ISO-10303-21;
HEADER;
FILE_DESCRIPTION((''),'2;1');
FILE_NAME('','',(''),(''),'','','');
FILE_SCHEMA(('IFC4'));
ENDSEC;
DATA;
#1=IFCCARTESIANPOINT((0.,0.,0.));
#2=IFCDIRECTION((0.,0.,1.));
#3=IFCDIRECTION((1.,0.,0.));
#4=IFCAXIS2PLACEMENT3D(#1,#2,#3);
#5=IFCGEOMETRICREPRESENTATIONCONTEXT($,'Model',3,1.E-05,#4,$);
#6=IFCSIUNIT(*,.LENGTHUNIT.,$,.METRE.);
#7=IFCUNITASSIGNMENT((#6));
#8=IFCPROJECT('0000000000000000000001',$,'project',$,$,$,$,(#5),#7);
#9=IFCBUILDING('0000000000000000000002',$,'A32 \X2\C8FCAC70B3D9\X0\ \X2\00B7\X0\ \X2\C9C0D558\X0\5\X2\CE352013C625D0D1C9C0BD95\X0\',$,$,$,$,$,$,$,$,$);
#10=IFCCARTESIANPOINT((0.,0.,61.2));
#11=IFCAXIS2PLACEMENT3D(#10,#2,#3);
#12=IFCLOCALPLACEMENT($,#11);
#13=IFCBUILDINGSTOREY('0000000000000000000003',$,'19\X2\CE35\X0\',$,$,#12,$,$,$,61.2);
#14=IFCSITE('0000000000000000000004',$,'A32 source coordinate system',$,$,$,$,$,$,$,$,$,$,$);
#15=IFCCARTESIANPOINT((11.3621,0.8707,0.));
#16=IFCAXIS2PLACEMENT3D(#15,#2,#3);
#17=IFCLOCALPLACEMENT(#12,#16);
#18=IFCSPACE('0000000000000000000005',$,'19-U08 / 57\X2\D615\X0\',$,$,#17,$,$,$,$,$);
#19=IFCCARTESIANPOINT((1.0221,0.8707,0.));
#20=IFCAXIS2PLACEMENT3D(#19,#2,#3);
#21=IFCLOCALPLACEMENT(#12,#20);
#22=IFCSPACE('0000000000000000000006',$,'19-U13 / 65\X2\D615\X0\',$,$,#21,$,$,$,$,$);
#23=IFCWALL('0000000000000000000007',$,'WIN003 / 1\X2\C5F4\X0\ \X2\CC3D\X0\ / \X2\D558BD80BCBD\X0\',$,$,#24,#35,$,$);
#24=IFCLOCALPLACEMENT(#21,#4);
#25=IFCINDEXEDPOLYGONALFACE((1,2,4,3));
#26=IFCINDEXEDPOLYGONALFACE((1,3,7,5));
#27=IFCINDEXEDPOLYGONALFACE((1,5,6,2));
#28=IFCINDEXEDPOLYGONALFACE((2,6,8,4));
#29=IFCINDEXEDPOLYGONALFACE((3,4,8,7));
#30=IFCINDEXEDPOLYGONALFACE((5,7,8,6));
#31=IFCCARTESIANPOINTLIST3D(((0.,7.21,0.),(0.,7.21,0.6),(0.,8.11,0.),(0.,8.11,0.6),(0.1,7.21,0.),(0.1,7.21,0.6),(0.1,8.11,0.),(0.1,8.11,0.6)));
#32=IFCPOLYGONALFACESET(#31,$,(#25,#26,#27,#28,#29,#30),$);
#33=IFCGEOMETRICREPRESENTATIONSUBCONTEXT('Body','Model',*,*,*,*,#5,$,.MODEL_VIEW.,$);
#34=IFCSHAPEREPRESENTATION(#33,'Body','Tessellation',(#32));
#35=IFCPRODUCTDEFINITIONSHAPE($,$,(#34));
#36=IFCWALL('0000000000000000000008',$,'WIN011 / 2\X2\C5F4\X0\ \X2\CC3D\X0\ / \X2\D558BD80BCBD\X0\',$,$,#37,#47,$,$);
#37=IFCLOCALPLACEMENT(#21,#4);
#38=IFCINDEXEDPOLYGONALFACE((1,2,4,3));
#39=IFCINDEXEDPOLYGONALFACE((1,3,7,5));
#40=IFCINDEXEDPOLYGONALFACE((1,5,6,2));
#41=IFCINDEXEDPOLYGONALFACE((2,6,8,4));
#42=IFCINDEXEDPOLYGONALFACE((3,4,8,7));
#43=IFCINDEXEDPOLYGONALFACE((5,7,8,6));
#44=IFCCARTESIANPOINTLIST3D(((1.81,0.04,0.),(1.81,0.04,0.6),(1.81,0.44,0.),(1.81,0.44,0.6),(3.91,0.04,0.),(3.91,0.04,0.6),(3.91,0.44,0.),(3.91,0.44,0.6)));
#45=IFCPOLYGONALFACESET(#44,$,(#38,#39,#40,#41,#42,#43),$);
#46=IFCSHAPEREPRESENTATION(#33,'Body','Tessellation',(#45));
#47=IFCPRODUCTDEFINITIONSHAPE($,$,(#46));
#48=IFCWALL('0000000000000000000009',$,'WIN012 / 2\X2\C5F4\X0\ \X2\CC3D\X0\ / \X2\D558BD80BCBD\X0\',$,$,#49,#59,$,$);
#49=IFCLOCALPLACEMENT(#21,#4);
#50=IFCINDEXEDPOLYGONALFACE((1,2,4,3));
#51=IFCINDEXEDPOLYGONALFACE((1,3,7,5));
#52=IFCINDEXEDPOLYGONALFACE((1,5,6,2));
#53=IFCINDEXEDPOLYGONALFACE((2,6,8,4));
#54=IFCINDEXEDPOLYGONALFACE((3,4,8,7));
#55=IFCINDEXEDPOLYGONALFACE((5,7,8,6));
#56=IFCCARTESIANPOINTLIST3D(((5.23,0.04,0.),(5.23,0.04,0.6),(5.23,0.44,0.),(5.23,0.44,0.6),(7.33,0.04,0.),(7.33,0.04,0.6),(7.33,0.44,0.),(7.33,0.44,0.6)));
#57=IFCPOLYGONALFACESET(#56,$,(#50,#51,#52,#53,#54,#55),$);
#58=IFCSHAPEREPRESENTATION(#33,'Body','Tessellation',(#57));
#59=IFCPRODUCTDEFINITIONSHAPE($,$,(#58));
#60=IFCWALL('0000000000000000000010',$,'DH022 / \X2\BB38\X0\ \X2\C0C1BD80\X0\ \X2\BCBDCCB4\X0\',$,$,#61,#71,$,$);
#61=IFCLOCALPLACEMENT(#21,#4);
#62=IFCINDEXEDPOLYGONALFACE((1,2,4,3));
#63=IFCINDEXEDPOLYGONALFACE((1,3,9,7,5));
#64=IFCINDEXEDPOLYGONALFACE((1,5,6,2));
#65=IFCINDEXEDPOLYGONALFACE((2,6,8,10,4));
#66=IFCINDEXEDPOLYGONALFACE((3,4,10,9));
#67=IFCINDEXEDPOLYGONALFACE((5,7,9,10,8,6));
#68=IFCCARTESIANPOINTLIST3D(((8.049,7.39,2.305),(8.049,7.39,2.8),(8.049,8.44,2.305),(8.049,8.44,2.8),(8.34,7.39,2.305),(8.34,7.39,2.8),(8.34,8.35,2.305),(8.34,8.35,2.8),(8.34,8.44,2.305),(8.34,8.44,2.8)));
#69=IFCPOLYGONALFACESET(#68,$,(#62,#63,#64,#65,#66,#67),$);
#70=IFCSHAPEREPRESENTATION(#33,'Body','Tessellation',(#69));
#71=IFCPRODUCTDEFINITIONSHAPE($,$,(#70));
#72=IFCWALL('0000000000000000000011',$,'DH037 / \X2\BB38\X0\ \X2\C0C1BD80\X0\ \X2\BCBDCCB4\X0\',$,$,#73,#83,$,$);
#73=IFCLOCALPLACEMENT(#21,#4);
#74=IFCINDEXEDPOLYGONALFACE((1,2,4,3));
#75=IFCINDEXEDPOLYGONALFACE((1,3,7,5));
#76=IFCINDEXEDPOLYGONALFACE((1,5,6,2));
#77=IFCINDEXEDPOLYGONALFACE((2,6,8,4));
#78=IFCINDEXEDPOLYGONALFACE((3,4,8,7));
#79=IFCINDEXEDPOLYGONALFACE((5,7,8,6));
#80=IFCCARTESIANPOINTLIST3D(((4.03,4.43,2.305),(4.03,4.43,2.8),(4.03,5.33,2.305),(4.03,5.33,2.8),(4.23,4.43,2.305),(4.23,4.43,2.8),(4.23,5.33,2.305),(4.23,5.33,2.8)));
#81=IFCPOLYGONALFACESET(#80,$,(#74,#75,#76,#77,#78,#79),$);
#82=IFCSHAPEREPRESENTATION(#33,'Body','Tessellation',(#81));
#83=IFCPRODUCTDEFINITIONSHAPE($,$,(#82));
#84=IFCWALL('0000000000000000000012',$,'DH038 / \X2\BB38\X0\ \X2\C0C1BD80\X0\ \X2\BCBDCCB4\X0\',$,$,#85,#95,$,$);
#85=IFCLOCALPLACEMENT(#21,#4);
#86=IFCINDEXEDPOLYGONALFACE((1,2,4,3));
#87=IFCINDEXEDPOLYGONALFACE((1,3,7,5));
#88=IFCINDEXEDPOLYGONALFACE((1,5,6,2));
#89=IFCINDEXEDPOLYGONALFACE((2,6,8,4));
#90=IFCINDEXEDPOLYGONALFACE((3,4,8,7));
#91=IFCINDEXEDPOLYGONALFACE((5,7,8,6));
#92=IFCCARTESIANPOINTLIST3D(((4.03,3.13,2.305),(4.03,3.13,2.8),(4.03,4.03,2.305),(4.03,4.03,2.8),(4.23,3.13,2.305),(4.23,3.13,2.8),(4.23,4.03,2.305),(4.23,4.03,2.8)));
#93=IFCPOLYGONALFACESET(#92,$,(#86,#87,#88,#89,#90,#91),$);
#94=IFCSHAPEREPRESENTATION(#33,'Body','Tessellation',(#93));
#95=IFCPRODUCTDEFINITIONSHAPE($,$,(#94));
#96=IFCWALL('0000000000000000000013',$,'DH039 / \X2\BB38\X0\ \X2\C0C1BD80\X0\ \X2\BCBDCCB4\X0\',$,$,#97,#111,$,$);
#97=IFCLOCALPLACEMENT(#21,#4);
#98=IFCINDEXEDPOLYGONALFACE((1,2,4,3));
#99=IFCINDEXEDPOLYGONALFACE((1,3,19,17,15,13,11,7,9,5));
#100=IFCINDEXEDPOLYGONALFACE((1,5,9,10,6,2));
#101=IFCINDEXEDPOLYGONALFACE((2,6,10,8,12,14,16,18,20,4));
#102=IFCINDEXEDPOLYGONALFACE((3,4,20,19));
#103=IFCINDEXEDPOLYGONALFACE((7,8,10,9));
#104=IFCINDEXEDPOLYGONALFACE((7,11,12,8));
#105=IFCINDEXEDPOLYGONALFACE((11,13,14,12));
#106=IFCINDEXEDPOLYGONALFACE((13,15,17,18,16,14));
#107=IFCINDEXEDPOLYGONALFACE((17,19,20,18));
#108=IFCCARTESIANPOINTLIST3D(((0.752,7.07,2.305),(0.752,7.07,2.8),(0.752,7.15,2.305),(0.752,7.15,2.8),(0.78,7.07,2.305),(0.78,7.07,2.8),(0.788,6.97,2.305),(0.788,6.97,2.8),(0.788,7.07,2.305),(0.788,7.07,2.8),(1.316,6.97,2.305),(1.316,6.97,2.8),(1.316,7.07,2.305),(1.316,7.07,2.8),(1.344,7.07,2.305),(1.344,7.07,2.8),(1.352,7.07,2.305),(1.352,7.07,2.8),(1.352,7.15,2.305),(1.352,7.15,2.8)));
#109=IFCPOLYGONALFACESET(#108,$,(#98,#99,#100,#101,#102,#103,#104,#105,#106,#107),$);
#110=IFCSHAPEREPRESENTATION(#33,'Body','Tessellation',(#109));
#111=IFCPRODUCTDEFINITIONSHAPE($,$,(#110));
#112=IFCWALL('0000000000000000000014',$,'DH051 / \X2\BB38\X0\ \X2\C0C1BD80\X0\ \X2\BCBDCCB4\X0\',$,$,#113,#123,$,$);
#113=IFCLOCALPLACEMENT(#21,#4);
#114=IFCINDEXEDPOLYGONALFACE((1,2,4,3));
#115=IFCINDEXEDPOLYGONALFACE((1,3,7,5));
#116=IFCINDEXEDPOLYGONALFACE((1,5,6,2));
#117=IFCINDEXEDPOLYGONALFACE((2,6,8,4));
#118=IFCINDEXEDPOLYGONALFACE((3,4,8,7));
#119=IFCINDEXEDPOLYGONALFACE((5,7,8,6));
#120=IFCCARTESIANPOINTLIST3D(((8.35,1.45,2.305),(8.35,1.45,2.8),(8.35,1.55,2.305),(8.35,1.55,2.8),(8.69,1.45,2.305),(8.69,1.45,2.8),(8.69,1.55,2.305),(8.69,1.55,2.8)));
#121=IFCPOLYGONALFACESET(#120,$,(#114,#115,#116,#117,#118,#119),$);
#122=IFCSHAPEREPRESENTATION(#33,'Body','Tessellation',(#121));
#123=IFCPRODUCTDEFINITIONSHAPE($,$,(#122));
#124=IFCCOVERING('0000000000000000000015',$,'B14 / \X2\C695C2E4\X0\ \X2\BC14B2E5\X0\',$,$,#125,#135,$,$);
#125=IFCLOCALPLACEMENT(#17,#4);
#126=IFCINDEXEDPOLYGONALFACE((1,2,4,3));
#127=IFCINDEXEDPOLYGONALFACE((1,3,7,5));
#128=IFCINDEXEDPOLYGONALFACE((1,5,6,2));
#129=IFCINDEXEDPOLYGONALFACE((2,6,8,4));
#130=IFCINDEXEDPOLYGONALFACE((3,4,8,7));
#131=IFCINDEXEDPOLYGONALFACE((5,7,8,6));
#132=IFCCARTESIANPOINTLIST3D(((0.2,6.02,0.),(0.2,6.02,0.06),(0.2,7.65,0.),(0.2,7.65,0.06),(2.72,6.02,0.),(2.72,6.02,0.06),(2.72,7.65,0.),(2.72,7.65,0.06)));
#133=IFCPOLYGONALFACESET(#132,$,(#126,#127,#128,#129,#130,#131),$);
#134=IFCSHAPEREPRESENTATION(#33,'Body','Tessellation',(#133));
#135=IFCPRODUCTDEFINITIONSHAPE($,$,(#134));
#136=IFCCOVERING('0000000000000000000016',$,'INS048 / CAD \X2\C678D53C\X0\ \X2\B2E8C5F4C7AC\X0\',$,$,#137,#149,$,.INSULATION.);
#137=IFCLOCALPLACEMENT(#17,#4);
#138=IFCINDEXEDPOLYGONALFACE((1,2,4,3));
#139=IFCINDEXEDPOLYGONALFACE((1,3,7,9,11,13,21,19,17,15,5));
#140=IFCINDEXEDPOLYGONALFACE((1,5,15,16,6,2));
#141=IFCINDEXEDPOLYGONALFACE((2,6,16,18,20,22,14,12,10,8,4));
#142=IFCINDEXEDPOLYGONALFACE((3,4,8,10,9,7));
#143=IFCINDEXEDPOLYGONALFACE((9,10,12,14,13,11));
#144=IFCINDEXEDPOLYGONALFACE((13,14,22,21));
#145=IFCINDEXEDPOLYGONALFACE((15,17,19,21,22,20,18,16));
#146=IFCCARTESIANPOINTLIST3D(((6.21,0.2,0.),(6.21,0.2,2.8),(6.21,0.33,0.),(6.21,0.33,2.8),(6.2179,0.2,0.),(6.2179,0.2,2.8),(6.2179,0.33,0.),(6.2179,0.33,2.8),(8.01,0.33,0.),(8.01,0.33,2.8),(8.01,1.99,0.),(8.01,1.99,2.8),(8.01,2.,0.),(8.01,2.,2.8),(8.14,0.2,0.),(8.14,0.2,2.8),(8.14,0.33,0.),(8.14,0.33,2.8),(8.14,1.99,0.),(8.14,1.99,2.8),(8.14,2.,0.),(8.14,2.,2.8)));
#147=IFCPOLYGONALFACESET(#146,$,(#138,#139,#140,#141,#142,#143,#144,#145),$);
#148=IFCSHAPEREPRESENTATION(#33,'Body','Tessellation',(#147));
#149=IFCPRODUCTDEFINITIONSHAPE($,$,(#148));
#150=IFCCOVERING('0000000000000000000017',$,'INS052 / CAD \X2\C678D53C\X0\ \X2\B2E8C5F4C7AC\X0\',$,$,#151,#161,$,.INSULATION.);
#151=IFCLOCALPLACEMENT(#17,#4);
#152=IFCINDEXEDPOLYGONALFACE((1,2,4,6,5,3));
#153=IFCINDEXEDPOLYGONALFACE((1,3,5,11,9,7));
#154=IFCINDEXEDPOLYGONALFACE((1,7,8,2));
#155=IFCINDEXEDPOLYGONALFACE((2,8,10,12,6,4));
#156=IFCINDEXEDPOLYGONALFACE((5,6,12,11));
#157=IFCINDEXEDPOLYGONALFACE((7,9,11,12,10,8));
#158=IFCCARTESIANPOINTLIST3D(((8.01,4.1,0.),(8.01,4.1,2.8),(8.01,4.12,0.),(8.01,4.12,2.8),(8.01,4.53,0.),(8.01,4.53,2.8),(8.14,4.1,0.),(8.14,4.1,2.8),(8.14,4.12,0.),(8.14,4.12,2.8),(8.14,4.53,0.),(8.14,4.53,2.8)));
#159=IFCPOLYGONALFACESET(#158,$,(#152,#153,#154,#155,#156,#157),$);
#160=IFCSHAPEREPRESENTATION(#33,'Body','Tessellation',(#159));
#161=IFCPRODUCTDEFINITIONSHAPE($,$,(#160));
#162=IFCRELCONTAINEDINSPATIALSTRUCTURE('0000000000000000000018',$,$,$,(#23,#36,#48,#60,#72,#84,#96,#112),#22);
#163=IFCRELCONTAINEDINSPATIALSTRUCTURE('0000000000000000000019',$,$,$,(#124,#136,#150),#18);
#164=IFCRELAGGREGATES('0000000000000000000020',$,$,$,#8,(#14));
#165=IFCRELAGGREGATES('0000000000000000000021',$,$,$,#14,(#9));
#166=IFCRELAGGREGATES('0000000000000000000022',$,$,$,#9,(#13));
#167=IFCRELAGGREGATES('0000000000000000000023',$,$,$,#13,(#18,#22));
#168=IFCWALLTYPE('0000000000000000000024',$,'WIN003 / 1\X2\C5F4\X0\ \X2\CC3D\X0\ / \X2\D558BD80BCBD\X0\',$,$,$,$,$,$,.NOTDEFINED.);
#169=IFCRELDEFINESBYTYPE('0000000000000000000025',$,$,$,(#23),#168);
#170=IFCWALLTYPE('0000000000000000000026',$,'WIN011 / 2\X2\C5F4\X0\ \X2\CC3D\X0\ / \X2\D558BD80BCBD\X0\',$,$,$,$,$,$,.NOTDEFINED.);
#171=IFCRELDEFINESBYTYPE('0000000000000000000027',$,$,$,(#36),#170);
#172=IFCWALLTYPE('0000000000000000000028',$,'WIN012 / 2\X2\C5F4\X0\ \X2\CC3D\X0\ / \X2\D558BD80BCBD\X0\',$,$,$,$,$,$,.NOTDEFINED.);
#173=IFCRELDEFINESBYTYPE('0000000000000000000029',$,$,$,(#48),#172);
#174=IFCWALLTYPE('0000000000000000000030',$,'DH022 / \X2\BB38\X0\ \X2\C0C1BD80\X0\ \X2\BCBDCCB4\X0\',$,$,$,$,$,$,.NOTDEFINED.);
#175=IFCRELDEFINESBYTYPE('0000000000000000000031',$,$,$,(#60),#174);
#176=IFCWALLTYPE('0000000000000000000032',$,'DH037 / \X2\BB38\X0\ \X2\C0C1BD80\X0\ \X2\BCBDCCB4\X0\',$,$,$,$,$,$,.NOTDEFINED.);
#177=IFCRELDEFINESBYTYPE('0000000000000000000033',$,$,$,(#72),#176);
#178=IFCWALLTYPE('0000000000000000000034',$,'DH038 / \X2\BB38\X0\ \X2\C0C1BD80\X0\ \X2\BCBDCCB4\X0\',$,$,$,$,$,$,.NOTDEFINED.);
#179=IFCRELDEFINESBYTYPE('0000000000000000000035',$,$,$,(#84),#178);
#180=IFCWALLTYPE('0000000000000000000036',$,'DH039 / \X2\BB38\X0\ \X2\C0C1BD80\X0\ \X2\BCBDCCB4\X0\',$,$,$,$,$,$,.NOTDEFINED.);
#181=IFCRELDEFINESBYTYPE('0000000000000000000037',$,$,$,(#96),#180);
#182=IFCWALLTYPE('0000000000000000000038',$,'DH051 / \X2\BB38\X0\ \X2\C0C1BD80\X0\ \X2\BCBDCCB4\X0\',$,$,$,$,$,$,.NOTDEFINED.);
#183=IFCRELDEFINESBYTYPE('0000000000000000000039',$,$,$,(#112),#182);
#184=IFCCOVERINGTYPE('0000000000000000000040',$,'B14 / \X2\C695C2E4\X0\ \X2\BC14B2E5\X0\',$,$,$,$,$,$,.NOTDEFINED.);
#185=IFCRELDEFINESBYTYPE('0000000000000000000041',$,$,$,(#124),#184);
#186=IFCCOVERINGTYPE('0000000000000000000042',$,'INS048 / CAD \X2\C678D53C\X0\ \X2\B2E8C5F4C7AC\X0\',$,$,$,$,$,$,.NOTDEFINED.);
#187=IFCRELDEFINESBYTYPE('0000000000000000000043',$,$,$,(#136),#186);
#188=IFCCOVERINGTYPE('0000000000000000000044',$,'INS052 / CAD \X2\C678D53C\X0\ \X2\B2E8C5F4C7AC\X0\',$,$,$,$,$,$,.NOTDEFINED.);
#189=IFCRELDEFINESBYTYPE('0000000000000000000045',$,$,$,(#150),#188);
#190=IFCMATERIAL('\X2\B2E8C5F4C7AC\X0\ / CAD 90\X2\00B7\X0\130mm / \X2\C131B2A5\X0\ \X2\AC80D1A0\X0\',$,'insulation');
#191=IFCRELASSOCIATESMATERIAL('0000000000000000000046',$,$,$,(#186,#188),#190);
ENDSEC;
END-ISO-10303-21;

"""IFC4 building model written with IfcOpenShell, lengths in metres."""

from ifc_helpers import new_model, si_unit, frame, origin, origin_with_axes, place, context, subcontext, project, spatial, polyline, outline, extrude, source, transform, mapped, material, type_object, type_shapes, element, save


model = new_model("IFC4")

# Units and contexts
model_context = context("Model", 3, precision=1e-05, world=origin_with_axes())
body_context = subcontext(model_context, "Body", "Model", "MODEL_VIEW")
ifc_project = project(units=[si_unit("LENGTHUNIT", "METRE")], contexts=[model_context])

# Site, building, storey, space
site = spatial("IfcSite", under=ifc_project, Name="A32 source coordinate system")
building = spatial("IfcBuilding", under=site, Name="A32 주거동 · 지하5층–옥탑지붕")
storey_placement = place(None, frame((0.0, 0.0, 61.2), z_axis=(0.0, 0.0, 1.0), x_axis=(1.0, 0.0, 0.0)))
storey = spatial("IfcBuildingStorey", under=building, at=storey_placement, Name="19층", Elevation=61.2)
space_1_placement = place(storey_placement, frame((11.3621, 0.8707, 0.0), z_axis=(0.0, 0.0, 1.0), x_axis=(1.0, 0.0, 0.0)))
space_1 = spatial("IfcSpace", under=storey, at=space_1_placement, Name="19-U08 / 57형")

# Shared definitions
space_2_placement = place(storey_placement, frame((1.0221, 0.8707, 0.0), z_axis=(0.0, 0.0, 1.0), x_axis=(1.0, 0.0, 0.0)))
space_2 = spatial("IfcSpace", under=storey, at=space_2_placement, Name="19-U13 / 65형")

# Walls
wall_type_1 = type_object("IfcWallType", Name="WIN003 / 1열 창 / 하부벽", PredefinedType="NOTDEFINED")
shared_shape_1 = source(origin(), body_context, "Body", "SweptSolid", [
    extrude(outline(polyline([(0.0, 8.11), (0.1, 8.11), (0.1, 7.21), (0.0, 7.21), (0.0, 8.11)])), origin(), (0.0, 0.0, 1.0), 0.6),
])
type_shapes(wall_type_1, [shared_shape_1])
wall_1_placement = place(space_2_placement, origin_with_axes())
element("IfcWall", 1, at=wall_1_placement, inside=space_2, type_object=wall_type_1, Name="WIN003 / 1열 창 / 하부벽", context=body_context, shape_type="MappedRepresentation", body=[
    mapped(shared_shape_1, transform((0.0, 0.0, 0.0), scale=1.0)),
])
wall_type_2 = type_object("IfcWallType", Name="WIN011 / 2열 창 / 하부벽", PredefinedType="NOTDEFINED")
shared_shape_2 = source(origin(), body_context, "Body", "SweptSolid", [
    extrude(outline(polyline([(1.81, 0.44), (3.91, 0.44), (3.91, 0.04), (1.81, 0.04), (1.81, 0.44)])), origin(), (0.0, 0.0, 1.0), 0.6),
])
type_shapes(wall_type_2, [shared_shape_2])
wall_2_placement = place(space_2_placement, origin_with_axes())
element("IfcWall", 2, at=wall_2_placement, inside=space_2, type_object=wall_type_2, Name="WIN011 / 2열 창 / 하부벽", context=body_context, shape_type="MappedRepresentation", body=[
    mapped(shared_shape_2, transform((0.0, 0.0, 0.0), scale=1.0)),
])
wall_type_3 = type_object("IfcWallType", Name="WIN012 / 2열 창 / 하부벽", PredefinedType="NOTDEFINED")
shared_shape_3 = source(origin(), body_context, "Body", "SweptSolid", [
    extrude(outline(polyline([(5.23, 0.44), (7.33, 0.44), (7.33, 0.04), (5.23, 0.04), (5.23, 0.44)])), origin(), (0.0, 0.0, 1.0), 0.6),
])
type_shapes(wall_type_3, [shared_shape_3])
wall_3_placement = place(space_2_placement, origin_with_axes())
element("IfcWall", 3, at=wall_3_placement, inside=space_2, type_object=wall_type_3, Name="WIN012 / 2열 창 / 하부벽", context=body_context, shape_type="MappedRepresentation", body=[
    mapped(shared_shape_3, transform((0.0, 0.0, 0.0), scale=1.0)),
])
wall_type_4 = type_object("IfcWallType", Name="DH022 / 문 상부 벽체", PredefinedType="NOTDEFINED")
shared_shape_4 = source(origin(), body_context, "Body", "SweptSolid", [
    extrude(outline(polyline([(8.049, 7.39), (8.049, 8.44), (8.34, 8.44), (8.34, 8.35), (8.34, 8.35), (8.34, 7.39), (8.049, 7.39)])), frame((0.0, 0.0, 2.305)), (0.0, 0.0, 1.0), 0.495),
])
type_shapes(wall_type_4, [shared_shape_4])
wall_4_placement = place(space_2_placement, origin_with_axes())
element("IfcWall", 4, at=wall_4_placement, inside=space_2, type_object=wall_type_4, Name="DH022 / 문 상부 벽체", context=body_context, shape_type="MappedRepresentation", body=[
    mapped(shared_shape_4, transform((0.0, 0.0, 0.0), scale=1.0)),
])
wall_type_5 = type_object("IfcWallType", Name="DH037 / 문 상부 벽체", PredefinedType="NOTDEFINED")
shared_shape_5 = source(origin(), body_context, "Body", "SweptSolid", [
    extrude(outline(polyline([(4.23, 5.33), (4.23, 4.43), (4.03, 4.43), (4.03, 5.33), (4.23, 5.33)])), frame((0.0, 0.0, 2.305)), (0.0, 0.0, 1.0), 0.495),
])
type_shapes(wall_type_5, [shared_shape_5])
wall_5_placement = place(space_2_placement, origin_with_axes())
element("IfcWall", 5, at=wall_5_placement, inside=space_2, type_object=wall_type_5, Name="DH037 / 문 상부 벽체", context=body_context, shape_type="MappedRepresentation", body=[
    mapped(shared_shape_5, transform((0.0, 0.0, 0.0), scale=1.0)),
])
wall_type_6 = type_object("IfcWallType", Name="DH038 / 문 상부 벽체", PredefinedType="NOTDEFINED")
shared_shape_6 = source(origin(), body_context, "Body", "SweptSolid", [
    extrude(outline(polyline([(4.23, 4.03), (4.23, 3.13), (4.03, 3.13), (4.03, 4.03), (4.23, 4.03)])), frame((0.0, 0.0, 2.305)), (0.0, 0.0, 1.0), 0.495),
])
type_shapes(wall_type_6, [shared_shape_6])
wall_6_placement = place(space_2_placement, origin_with_axes())
element("IfcWall", 6, at=wall_6_placement, inside=space_2, type_object=wall_type_6, Name="DH038 / 문 상부 벽체", context=body_context, shape_type="MappedRepresentation", body=[
    mapped(shared_shape_6, transform((0.0, 0.0, 0.0), scale=1.0)),
])
wall_type_7 = type_object("IfcWallType", Name="DH039 / 문 상부 벽체", PredefinedType="NOTDEFINED")
shared_shape_7 = source(origin(), body_context, "Body", "SweptSolid", [
    extrude(outline(polyline([(1.316, 7.07), (1.316, 6.97), (0.788, 6.97), (0.788, 7.07), (0.78, 7.07), (0.752, 7.07), (0.752, 7.15), (1.352, 7.15), (1.352, 7.07), (1.344, 7.07), (1.316, 7.07)])), frame((0.0, 0.0, 2.305)), (0.0, 0.0, 1.0), 0.495),
])
type_shapes(wall_type_7, [shared_shape_7])
wall_7_placement = place(space_2_placement, origin_with_axes())
element("IfcWall", 7, at=wall_7_placement, inside=space_2, type_object=wall_type_7, Name="DH039 / 문 상부 벽체", context=body_context, shape_type="MappedRepresentation", body=[
    mapped(shared_shape_7, transform((0.0, 0.0, 0.0), scale=1.0)),
])
wall_type_8 = type_object("IfcWallType", Name="DH051 / 문 상부 벽체", PredefinedType="NOTDEFINED")
shared_shape_8 = source(origin(), body_context, "Body", "SweptSolid", [
    extrude(outline(polyline([(8.69, 1.55), (8.69, 1.45), (8.35, 1.45), (8.35, 1.55), (8.69, 1.55)])), frame((0.0, 0.0, 2.305)), (0.0, 0.0, 1.0), 0.495),
])
type_shapes(wall_type_8, [shared_shape_8])
wall_8_placement = place(space_2_placement, origin_with_axes())
element("IfcWall", 8, at=wall_8_placement, inside=space_2, type_object=wall_type_8, Name="DH051 / 문 상부 벽체", context=body_context, shape_type="MappedRepresentation", body=[
    mapped(shared_shape_8, transform((0.0, 0.0, 0.0), scale=1.0)),
])

# Coverings
covering_type_1 = type_object("IfcCoveringType", Name="B14 / 욕실 바닥", PredefinedType="NOTDEFINED")
shared_shape_9 = source(origin(), body_context, "Body", "SweptSolid", [
    extrude(outline(polyline([(0.2, 7.65), (2.72, 7.65), (2.72, 6.02), (0.2, 6.02), (0.2, 7.65)])), origin(), (0.0, 0.0, 1.0), 0.06),
])
type_shapes(covering_type_1, [shared_shape_9])
covering_1_placement = place(space_1_placement, origin_with_axes())
element("IfcCovering", 9, at=covering_1_placement, inside=space_1, type_object=covering_type_1, Name="B14 / 욕실 바닥", context=body_context, shape_type="MappedRepresentation", body=[
    mapped(shared_shape_9, transform((0.0, 0.0, 0.0), scale=1.0)),
])
ifc_material = material(Name="단열재 / CAD 90·130mm / 성능 검토", Category="insulation")
covering_type_2 = type_object("IfcCoveringType", Name="INS048 / CAD 외피 단열재", PredefinedType="NOTDEFINED", material=ifc_material)
shared_shape_10 = source(origin(), body_context, "Body", "SweptSolid", [
    extrude(outline(polyline([(8.01, 1.99), (8.01, 2.0), (8.14, 2.0), (8.14, 1.99), (8.14, 0.33), (8.14, 0.2), (6.2179, 0.2), (6.21, 0.2), (6.21, 0.33), (6.2179, 0.33), (8.01, 0.33), (8.01, 1.99)])), origin(), (0.0, 0.0, 1.0), 2.8),
])
type_shapes(covering_type_2, [shared_shape_10])
covering_2_placement = place(space_1_placement, origin_with_axes())
element("IfcCovering", 10, at=covering_2_placement, inside=space_1, type_object=covering_type_2, Name="INS048 / CAD 외피 단열재", PredefinedType="INSULATION", context=body_context, shape_type="MappedRepresentation", body=[
    mapped(shared_shape_10, transform((0.0, 0.0, 0.0), scale=1.0)),
])
covering_type_3 = type_object("IfcCoveringType", Name="INS052 / CAD 외피 단열재", PredefinedType="NOTDEFINED", material=ifc_material)
shared_shape_11 = source(origin(), body_context, "Body", "SweptSolid", [
    extrude(outline(polyline([(8.14, 4.1), (8.01, 4.1), (8.01, 4.12), (8.01, 4.53), (8.14, 4.53), (8.14, 4.12), (8.14, 4.1)])), origin(), (0.0, 0.0, 1.0), 2.8),
])
type_shapes(covering_type_3, [shared_shape_11])
covering_3_placement = place(space_1_placement, origin_with_axes())
element("IfcCovering", 11, at=covering_3_placement, inside=space_1, type_object=covering_type_3, Name="INS052 / CAD 외피 단열재", PredefinedType="INSULATION", context=body_context, shape_type="MappedRepresentation", body=[
    mapped(shared_shape_11, transform((0.0, 0.0, 0.0), scale=1.0)),
])

save(model, "model.ifc")
